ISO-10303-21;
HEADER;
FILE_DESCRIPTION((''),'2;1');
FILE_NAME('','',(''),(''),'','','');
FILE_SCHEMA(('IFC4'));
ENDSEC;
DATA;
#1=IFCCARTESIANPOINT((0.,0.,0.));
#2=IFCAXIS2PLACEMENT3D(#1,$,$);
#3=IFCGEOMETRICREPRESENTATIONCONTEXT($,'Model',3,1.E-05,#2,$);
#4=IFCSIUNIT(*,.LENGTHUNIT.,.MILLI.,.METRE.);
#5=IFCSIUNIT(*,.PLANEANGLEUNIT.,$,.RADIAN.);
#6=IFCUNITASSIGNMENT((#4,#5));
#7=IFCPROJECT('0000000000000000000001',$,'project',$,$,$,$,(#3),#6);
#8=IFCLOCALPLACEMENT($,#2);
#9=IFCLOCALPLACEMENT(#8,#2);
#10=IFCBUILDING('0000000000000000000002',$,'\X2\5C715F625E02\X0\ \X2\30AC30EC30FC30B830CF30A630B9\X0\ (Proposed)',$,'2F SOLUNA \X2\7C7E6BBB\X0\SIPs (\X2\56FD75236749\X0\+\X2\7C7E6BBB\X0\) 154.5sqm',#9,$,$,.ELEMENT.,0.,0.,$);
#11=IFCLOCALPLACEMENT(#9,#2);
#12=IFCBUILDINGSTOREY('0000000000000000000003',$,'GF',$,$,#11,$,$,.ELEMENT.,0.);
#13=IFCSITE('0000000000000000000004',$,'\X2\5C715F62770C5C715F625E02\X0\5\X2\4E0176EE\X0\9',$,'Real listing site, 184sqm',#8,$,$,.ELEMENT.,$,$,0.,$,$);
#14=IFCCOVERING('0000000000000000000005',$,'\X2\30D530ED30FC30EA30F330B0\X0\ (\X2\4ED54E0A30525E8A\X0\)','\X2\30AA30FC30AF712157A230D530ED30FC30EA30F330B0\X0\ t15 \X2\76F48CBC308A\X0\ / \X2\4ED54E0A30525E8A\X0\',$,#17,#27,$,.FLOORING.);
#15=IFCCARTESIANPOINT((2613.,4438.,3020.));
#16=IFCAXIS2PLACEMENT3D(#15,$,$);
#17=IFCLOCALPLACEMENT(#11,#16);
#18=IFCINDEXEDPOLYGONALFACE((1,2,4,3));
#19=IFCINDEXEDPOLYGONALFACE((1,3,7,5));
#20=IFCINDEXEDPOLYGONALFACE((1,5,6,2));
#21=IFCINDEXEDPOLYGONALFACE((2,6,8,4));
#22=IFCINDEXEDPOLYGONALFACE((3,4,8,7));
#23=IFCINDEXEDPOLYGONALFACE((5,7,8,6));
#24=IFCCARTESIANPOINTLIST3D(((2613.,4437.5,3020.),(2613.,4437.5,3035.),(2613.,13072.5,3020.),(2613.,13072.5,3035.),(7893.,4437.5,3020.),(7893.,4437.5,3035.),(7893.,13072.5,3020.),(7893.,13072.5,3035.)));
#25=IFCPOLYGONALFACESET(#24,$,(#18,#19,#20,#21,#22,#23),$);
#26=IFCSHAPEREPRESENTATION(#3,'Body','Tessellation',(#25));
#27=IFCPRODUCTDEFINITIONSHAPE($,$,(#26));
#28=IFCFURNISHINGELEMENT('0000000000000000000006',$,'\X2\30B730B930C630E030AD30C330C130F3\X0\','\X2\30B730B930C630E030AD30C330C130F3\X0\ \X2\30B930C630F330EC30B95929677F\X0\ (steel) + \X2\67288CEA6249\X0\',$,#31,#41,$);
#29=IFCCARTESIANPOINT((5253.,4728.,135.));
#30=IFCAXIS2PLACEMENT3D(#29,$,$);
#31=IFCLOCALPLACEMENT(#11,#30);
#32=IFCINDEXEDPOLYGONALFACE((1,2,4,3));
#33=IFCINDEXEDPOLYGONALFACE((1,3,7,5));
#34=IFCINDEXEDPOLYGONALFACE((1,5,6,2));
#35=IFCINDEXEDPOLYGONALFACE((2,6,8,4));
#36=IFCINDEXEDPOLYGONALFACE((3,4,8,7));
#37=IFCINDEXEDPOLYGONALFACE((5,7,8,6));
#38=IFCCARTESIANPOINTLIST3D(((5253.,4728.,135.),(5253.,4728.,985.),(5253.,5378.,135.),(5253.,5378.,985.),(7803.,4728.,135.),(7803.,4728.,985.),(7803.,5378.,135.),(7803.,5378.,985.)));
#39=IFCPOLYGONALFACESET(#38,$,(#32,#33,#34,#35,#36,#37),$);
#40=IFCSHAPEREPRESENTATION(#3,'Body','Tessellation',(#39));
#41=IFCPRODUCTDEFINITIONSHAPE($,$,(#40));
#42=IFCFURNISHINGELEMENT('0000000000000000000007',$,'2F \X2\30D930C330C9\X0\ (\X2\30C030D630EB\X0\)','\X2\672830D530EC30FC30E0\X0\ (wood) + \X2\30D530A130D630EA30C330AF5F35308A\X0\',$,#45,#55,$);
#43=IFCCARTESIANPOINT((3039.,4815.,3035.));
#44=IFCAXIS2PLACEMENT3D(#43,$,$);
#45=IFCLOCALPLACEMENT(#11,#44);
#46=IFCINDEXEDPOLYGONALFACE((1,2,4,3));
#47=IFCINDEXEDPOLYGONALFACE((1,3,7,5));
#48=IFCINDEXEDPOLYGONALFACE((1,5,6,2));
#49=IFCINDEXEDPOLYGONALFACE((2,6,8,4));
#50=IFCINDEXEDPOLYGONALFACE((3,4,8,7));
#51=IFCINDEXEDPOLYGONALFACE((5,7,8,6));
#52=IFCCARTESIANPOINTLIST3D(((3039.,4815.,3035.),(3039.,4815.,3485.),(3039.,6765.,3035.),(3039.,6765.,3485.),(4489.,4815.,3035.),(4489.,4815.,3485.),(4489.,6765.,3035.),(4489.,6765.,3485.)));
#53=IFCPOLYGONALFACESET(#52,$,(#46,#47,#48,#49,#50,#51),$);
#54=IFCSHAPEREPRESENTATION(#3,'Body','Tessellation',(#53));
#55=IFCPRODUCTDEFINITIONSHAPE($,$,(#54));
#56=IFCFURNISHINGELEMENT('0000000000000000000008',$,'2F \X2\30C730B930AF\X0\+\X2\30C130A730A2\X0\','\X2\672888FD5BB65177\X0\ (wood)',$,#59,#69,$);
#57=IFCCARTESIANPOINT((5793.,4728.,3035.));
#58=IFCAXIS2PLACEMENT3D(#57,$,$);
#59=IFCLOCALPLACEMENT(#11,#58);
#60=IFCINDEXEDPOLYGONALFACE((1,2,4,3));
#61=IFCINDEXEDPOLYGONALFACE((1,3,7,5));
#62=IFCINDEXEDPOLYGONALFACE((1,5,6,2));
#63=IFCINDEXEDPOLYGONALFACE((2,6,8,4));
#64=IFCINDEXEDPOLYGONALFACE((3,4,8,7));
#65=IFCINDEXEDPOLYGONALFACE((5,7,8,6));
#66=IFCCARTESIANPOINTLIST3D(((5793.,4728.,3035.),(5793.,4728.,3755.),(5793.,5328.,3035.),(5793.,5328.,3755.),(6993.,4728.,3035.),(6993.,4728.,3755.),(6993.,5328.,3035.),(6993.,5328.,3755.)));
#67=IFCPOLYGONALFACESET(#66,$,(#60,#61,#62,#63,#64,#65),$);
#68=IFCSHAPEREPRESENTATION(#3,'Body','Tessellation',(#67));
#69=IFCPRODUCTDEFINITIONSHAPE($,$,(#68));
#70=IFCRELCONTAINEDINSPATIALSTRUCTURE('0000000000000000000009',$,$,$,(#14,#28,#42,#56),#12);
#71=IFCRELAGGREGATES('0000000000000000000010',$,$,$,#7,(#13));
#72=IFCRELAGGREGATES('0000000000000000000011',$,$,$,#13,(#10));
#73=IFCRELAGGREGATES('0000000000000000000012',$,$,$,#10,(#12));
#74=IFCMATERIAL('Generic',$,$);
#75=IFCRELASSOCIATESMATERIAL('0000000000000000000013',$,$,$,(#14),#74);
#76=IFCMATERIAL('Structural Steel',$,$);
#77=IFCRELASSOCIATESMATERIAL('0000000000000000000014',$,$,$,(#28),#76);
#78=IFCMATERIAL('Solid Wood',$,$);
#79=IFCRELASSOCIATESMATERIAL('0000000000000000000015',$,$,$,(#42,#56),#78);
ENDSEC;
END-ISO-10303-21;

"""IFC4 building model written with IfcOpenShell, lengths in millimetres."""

from ifc_helpers import new_model, si_unit, frame, frame_2d, origin, place, context, project, spatial, rectangle, extrude, material, element, save


model = new_model("IFC4")

# Units and contexts
model_context = context("Model", 3, precision=1e-05, world=origin())
ifc_project = project(units=[si_unit("LENGTHUNIT", "METRE", prefix="MILLI"), si_unit("PLANEANGLEUNIT", "RADIAN")], contexts=[model_context])

# Site, building, storey
site_placement = place(None, origin())
site = spatial("IfcSite", under=ifc_project, at=site_placement, Name="山形県山形市5丁目9", ObjectType="Real listing site, 184sqm", CompositionType="ELEMENT", RefElevation=0.0)
building_placement = place(site_placement, origin())
building = spatial("IfcBuilding", under=site, at=building_placement, Name="山形市 ガレージハウス (Proposed)", ObjectType="2F SOLUNA 籾殻SIPs (国産杉+籾殻) 154.5sqm", CompositionType="ELEMENT", ElevationOfRefHeight=0.0, ElevationOfTerrain=0.0)
storey_placement = place(building_placement, origin())
storey = spatial("IfcBuildingStorey", under=building, at=storey_placement, Name="GF", CompositionType="ELEMENT", Elevation=0.0)

# Shared definitions
ifc_material_1 = material(Name="Solid Wood")

# Shared definitions
ifc_material_2 = material(Name="Generic")

# Shared definitions
ifc_material_3 = material(Name="Structural Steel")

# Covering
covering_placement = place(storey_placement, frame((2613.0, 4438.0, 3020.0)))
element("IfcCovering", 1, at=covering_placement, inside=storey, material=ifc_material_2, Name="フローリング (仕上げ床)", Description="オーク無垢フローリング t15 直貼り / 仕上げ床", PredefinedType="FLOORING", context=model_context, shape_type="SweptSolid", body=[
    extrude(rectangle(XDim=5280.0, YDim=8635.0, at=frame_2d((2640.0, 4317.0))), frame((2613.0, 4438.0, 3020.0)), (0.0, 0.0, 1.0), 15.0),
])

# Furnishing elements
furnishing_1_placement = place(storey_placement, frame((5253.0, 4728.0, 135.0)))
element("IfcFurnishingElement", 2, at=furnishing_1_placement, inside=storey, material=ifc_material_3, Name="システムキッチン", Description="システムキッチン ステンレス天板 (steel) + 木質扉", context=model_context, shape_type="SweptSolid", body=[
    extrude(rectangle(XDim=2550.0, YDim=650.0, at=frame_2d((1275.0, 325.0))), frame((5253.0, 4728.0, 135.0)), (0.0, 0.0, 1.0), 850.0),
])
furnishing_2_placement = place(storey_placement, frame((3039.0, 4815.0, 3035.0)))
element("IfcFurnishingElement", 3, at=furnishing_2_placement, inside=storey, material=ifc_material_1, Name="2F ベッド (ダブル)", Description="木フレーム (wood) + ファブリック張り", context=model_context, shape_type="SweptSolid", body=[
    extrude(rectangle(XDim=1450.0, YDim=1950.0, at=frame_2d((725.0, 975.0))), frame((3039.0, 4815.0, 3035.0)), (0.0, 0.0, 1.0), 450.0),
])
furnishing_3_placement = place(storey_placement, frame((5793.0, 4728.0, 3035.0)))
element("IfcFurnishingElement", 4, at=furnishing_3_placement, inside=storey, material=ifc_material_1, Name="2F デスク+チェア", Description="木製家具 (wood)", context=model_context, shape_type="SweptSolid", body=[
    extrude(rectangle(XDim=1200.0, YDim=600.0, at=frame_2d((600.0, 300.0))), frame((5793.0, 4728.0, 3035.0)), (0.0, 0.0, 1.0), 720.0),
])

save(model, "model.ifc")
